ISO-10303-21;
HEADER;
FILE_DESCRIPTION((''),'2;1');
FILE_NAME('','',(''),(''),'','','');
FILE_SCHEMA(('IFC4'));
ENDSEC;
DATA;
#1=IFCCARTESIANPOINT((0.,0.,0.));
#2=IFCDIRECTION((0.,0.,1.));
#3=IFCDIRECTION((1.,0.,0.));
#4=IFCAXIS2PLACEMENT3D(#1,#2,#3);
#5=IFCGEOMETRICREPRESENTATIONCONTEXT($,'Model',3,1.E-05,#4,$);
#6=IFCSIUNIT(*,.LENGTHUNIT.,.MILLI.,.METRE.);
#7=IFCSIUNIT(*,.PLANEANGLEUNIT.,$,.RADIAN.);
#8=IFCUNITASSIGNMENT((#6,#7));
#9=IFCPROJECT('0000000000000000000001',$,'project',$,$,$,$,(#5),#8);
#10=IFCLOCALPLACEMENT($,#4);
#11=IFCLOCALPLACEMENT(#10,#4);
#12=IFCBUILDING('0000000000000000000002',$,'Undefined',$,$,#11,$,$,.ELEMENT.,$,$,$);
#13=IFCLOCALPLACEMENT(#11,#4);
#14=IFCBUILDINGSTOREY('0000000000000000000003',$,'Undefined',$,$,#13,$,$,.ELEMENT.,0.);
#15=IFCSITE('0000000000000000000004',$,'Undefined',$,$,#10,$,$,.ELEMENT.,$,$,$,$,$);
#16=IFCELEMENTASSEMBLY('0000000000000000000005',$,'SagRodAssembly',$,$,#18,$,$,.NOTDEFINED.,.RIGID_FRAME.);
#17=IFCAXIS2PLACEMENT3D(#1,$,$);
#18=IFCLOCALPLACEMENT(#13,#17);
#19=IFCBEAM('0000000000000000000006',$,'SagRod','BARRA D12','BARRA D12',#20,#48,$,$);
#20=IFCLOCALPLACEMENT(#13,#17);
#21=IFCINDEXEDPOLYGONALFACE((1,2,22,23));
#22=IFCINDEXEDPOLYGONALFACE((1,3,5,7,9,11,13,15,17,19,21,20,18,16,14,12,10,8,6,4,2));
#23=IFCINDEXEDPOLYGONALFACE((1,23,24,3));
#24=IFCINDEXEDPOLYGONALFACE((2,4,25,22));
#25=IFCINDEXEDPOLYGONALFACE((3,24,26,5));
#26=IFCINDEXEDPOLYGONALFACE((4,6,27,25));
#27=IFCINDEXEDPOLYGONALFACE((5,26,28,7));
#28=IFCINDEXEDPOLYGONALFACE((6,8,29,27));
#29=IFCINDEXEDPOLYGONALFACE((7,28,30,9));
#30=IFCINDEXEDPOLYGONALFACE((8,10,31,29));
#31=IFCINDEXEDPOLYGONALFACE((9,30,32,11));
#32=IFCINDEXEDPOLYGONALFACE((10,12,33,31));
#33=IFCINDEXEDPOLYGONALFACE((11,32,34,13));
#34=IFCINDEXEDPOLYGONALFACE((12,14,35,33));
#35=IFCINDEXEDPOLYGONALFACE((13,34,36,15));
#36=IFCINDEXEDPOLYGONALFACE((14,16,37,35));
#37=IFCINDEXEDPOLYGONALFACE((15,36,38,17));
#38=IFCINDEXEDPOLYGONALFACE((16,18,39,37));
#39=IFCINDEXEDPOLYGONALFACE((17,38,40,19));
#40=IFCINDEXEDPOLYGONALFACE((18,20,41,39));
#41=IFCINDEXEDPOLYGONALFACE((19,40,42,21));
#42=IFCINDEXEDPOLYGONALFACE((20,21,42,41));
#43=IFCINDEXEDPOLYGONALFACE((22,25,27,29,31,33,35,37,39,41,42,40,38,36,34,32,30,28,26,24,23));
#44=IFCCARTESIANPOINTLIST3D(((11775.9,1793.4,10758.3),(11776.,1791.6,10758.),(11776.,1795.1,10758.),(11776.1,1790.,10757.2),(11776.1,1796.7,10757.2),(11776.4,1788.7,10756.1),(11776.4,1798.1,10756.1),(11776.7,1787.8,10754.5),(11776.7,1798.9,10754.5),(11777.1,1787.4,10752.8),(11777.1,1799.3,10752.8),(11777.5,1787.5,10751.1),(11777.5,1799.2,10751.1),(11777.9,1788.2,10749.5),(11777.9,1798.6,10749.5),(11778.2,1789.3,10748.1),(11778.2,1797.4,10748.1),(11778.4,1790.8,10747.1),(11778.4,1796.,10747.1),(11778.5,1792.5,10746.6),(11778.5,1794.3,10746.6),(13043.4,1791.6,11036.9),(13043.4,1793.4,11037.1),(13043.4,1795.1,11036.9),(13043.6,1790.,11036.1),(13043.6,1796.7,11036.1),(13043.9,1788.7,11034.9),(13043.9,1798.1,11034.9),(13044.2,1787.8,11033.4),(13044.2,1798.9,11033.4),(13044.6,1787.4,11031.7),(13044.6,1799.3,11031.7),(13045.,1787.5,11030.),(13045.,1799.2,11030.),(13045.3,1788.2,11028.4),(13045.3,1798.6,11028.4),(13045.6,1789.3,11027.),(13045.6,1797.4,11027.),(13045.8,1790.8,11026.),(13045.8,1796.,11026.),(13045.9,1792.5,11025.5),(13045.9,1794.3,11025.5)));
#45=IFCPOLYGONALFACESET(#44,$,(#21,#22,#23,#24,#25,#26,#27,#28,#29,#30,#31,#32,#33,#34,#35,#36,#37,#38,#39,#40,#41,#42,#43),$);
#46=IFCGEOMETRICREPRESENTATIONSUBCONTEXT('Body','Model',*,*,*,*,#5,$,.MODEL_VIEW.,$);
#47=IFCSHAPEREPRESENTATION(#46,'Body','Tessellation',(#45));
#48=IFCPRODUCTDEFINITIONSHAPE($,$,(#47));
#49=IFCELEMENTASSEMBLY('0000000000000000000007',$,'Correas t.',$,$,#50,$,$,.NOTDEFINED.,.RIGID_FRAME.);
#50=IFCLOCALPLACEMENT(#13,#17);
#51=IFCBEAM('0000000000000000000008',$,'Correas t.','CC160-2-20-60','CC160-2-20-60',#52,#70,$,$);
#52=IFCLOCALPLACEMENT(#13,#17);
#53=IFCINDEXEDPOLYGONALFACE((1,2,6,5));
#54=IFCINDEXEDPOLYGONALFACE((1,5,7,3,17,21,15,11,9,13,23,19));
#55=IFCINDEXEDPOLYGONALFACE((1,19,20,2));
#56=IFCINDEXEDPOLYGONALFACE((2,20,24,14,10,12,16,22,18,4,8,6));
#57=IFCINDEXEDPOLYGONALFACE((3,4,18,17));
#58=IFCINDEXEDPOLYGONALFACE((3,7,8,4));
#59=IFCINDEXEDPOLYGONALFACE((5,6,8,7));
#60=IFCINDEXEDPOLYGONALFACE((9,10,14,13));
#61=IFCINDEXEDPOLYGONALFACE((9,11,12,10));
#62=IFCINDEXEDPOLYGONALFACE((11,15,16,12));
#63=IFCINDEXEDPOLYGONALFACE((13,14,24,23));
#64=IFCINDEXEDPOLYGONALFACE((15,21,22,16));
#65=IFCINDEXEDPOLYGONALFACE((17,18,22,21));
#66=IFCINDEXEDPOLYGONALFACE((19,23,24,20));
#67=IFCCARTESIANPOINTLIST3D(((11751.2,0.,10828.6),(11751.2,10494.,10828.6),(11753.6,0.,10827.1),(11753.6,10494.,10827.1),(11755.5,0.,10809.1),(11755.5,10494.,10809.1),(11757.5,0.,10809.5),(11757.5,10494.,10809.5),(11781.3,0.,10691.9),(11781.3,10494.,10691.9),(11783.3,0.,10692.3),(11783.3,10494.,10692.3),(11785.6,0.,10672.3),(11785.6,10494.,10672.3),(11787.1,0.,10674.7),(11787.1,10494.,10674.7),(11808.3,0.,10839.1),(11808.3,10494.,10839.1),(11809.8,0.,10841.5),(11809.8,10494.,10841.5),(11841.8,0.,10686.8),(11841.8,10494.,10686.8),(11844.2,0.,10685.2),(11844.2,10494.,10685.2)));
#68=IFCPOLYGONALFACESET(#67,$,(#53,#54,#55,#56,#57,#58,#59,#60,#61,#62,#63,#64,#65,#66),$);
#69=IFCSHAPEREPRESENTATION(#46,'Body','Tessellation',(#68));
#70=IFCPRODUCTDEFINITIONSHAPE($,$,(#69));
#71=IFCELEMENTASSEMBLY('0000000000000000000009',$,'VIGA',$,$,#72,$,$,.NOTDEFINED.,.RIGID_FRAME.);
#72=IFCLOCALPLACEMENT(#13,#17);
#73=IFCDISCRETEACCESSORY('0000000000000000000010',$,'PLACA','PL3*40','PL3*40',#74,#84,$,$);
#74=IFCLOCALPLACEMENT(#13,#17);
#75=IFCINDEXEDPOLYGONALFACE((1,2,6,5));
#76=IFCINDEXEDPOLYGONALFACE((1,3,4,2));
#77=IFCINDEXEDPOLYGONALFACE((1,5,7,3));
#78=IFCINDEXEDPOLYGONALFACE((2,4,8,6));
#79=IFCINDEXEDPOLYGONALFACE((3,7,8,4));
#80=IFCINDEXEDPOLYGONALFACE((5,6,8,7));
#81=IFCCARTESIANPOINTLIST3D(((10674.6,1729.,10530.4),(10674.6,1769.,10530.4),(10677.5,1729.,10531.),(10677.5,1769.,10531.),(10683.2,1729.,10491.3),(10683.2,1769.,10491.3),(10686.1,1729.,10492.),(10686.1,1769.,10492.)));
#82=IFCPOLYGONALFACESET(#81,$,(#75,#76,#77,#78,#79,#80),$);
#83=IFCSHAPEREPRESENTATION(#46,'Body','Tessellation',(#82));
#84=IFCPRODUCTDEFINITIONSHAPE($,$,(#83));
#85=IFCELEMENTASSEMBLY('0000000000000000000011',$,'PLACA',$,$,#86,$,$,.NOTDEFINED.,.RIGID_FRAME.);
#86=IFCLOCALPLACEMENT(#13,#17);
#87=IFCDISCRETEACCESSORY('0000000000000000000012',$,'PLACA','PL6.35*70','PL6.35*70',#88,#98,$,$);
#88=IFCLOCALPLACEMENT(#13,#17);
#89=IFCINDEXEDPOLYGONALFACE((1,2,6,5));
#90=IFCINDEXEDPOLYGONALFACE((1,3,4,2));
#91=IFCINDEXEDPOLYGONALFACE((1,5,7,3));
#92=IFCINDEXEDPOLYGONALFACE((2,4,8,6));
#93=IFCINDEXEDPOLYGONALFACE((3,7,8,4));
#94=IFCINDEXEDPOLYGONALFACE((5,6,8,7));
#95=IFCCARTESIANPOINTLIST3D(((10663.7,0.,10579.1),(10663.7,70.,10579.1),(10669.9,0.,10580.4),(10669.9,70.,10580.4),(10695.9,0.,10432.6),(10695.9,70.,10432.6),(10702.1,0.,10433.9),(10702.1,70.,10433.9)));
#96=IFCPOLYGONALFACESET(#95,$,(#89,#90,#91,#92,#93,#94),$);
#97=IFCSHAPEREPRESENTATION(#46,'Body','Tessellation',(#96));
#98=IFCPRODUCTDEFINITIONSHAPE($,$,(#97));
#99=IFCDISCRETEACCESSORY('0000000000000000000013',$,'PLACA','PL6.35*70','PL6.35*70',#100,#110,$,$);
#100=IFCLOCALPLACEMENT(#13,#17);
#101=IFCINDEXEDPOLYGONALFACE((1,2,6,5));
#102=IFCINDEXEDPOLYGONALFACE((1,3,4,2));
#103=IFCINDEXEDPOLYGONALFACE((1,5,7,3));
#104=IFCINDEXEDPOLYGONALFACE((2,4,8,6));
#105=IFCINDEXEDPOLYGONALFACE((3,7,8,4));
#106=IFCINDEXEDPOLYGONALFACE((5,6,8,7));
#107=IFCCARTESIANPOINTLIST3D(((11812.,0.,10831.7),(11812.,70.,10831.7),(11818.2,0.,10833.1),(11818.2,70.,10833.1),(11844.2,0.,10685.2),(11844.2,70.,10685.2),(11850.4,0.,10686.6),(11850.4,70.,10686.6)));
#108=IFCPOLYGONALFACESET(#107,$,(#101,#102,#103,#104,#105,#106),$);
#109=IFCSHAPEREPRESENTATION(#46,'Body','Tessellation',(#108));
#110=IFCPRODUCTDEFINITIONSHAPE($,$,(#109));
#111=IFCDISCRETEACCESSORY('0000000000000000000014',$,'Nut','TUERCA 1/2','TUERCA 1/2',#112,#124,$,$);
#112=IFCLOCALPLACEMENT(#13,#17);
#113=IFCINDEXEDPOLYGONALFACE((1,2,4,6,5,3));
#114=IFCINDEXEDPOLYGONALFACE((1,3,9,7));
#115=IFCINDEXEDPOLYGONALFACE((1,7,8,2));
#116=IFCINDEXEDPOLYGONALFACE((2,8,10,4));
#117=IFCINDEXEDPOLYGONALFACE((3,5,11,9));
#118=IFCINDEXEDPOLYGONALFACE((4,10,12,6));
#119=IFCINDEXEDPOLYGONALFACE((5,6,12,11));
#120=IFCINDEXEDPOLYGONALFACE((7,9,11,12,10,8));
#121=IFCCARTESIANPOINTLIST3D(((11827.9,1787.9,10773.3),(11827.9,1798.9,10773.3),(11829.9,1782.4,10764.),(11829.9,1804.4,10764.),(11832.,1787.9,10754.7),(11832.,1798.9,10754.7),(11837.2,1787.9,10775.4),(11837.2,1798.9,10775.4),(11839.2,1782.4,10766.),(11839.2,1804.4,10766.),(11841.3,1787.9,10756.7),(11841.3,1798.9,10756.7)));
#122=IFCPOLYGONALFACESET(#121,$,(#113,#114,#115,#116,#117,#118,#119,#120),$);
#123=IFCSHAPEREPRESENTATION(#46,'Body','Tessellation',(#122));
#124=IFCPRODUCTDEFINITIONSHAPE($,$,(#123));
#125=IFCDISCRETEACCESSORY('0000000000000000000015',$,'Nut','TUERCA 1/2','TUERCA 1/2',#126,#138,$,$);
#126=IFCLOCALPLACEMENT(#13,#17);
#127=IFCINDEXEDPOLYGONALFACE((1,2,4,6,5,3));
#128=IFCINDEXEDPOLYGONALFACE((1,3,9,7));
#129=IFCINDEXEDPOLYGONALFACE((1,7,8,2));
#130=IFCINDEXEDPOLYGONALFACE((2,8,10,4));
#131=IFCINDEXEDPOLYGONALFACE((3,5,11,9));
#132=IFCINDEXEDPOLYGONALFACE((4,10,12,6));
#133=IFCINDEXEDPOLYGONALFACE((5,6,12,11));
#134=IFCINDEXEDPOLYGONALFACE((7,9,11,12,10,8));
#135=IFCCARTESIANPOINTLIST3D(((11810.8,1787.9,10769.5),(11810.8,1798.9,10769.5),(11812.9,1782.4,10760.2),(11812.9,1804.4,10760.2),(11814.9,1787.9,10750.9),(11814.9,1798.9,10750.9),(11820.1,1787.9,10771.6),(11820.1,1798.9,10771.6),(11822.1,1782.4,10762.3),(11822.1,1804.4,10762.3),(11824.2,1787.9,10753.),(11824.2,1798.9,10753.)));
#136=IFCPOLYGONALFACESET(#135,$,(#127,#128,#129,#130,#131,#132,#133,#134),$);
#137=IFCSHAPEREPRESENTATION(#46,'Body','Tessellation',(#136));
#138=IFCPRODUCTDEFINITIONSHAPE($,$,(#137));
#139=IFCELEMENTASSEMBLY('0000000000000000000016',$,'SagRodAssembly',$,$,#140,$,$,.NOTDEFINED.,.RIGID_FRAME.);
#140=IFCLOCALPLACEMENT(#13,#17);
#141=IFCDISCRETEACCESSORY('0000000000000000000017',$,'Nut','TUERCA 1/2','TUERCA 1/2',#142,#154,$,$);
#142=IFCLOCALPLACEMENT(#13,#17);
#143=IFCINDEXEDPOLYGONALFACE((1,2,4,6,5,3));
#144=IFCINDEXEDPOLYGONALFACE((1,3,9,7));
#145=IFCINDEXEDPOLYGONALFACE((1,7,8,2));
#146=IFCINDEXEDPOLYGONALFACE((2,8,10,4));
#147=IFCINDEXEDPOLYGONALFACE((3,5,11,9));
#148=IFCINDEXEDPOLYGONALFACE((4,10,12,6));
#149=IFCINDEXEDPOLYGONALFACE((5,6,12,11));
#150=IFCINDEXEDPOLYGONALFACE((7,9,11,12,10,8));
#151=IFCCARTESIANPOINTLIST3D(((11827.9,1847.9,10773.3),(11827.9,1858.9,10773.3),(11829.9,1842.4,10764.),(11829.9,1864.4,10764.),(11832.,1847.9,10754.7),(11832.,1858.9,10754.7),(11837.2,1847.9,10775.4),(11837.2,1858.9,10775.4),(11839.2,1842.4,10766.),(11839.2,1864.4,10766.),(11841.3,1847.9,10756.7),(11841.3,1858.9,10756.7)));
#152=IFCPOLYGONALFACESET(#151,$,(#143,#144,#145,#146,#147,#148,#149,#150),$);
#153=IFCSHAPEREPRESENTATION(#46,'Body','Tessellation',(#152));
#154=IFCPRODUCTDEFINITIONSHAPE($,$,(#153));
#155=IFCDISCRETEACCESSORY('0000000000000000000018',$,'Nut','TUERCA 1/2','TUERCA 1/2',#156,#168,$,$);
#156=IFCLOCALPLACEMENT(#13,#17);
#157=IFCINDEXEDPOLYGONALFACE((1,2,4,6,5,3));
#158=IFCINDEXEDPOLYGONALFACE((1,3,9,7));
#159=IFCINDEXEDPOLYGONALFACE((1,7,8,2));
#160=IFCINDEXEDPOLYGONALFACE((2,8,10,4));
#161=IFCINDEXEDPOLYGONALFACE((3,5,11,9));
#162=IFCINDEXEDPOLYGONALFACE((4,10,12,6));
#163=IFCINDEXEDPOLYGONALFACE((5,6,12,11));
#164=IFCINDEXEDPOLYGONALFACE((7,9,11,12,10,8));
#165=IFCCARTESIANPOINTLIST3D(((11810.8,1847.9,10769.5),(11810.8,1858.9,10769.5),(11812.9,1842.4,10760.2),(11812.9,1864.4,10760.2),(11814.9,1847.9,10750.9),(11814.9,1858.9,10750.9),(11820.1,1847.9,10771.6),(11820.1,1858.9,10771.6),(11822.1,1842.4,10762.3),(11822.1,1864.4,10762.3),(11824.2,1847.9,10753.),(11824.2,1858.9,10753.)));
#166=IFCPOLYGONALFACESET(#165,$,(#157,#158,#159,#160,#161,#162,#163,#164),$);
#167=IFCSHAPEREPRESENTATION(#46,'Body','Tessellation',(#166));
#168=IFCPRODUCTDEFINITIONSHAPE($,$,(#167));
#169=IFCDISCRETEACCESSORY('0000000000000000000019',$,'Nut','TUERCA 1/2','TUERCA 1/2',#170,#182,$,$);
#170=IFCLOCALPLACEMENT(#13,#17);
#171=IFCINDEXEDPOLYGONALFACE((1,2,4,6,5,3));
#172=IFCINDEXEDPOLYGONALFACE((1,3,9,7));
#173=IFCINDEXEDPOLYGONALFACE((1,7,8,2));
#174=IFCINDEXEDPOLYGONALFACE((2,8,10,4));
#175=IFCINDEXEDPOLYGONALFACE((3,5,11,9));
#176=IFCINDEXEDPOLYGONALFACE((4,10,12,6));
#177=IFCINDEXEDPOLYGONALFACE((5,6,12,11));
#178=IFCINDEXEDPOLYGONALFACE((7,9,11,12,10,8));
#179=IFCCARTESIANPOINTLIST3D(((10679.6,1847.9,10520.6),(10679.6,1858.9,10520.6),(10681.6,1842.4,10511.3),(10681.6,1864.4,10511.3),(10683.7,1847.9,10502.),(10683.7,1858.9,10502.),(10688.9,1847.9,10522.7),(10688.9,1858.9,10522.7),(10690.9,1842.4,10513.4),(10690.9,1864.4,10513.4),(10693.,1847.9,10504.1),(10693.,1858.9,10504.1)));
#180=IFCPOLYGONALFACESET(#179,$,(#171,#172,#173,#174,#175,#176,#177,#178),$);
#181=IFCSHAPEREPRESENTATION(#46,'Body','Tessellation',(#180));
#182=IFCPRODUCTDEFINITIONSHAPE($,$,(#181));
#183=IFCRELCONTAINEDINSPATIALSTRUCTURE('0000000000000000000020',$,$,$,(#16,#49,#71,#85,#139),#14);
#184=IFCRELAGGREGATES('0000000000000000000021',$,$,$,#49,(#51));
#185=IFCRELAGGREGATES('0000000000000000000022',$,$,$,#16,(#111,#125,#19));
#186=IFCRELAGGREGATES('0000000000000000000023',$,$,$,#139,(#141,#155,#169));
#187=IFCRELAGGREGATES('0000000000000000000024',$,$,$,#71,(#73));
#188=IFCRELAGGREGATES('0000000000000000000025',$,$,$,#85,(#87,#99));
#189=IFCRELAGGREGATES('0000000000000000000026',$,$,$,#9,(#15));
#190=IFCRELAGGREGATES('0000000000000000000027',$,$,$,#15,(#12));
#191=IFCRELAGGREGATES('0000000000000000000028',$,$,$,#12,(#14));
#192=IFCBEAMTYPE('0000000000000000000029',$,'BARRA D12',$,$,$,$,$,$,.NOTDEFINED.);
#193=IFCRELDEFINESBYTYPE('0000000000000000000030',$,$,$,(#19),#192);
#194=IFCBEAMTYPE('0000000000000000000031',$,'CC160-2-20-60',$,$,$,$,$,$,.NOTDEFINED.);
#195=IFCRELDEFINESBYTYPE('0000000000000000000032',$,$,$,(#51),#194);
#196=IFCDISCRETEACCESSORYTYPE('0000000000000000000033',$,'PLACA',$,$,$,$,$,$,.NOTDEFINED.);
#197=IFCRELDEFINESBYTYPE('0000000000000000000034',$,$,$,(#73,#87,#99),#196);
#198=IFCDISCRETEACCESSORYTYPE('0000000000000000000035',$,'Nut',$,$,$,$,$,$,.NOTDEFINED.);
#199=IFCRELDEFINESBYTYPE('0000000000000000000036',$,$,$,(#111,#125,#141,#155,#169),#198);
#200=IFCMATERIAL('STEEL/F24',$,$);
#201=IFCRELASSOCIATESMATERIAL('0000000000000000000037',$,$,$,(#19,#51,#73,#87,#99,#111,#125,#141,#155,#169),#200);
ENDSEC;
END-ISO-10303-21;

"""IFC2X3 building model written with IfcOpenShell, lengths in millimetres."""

from ifc_helpers import new_model, si_unit, frame, origin_with_axes, origin_2d_with_axis, place, context, subcontext, project, spatial, polyline, rectangle, circle, c_section, outline, extrude, clip, halfspace, material, type_object, element, aggregate, save


model = new_model("IFC2X3")

# Units and contexts
model_context = context("Model", 3, precision=1e-05, world=origin_with_axes())
body_context = subcontext(model_context, "Body", "Model", "MODEL_VIEW")
ifc_project = project(units=[si_unit("LENGTHUNIT", "METRE", prefix="MILLI"), si_unit("PLANEANGLEUNIT", "RADIAN")], contexts=[model_context])

# Site, building, storey
site_placement = place(None, origin_with_axes())
site = spatial("IfcSite", under=ifc_project, at=site_placement, Name="Undefined", CompositionType="ELEMENT")
building_placement = place(site_placement, origin_with_axes())
building = spatial("IfcBuilding", under=site, at=building_placement, Name="Undefined", CompositionType="ELEMENT")
storey_placement = place(building_placement, origin_with_axes())
storey = spatial("IfcBuildingStorey", under=building, at=storey_placement, Name="Undefined", CompositionType="ELEMENT", Elevation=0.0)

# Element assemblies, beams
assembly_1_placement = place(storey_placement, origin_with_axes())
assembly_1 = element("IfcElementAssembly", 1, at=assembly_1_placement, inside=storey, Name="SagRodAssembly", AssemblyPlace="NOTDEFINED", PredefinedType="RIGID_FRAME")
ifc_material_1 = material(Name="STEEL/F24")
beam_type_1 = type_object("IfcBeamType", Name="BARRA D12", PredefinedType="NOTDEFINED")
beam_1_placement = place(assembly_1_placement, frame((11777.2, 1793.4, 10752.4), z_axis=(0.0, 1.0, 0.0), x_axis=(0.976639, 0.0, 0.214887)))
beam_1 = element("IfcBeam", 2, at=beam_1_placement, type_object=beam_type_1, material=ifc_material_1, Name="SagRod", Description="BARRA D12", ObjectType="BARRA D12", context=body_context, shape_type="SweptSolid", body=[
    extrude(circle(Radius=6.0, at=origin_2d_with_axis()), frame((1297.8, 0.0, 0.0), z_axis=(-1.0, 0.0, 0.0), x_axis=(0.0, -1.0, 0.0)), (0.0, 0.0, 1.0), 1297.8),
])
assembly_2_placement = place(storey_placement, origin_with_axes())
assembly_2 = element("IfcElementAssembly", 3, at=assembly_2_placement, inside=storey, Name="Correas t.", AssemblyPlace="NOTDEFINED", PredefinedType="RIGID_FRAME")
beam_type_2 = type_object("IfcBeamType", Name="CC160-2-20-60", PredefinedType="NOTDEFINED")
beam_2_placement = place(assembly_2_placement, frame((11797.7, 0.0, 10756.9), z_axis=(0.214887, 0.0, -0.976639), x_axis=(0.0, 1.0, 0.0)))
beam_2 = element("IfcBeam", 4, at=beam_2_placement, type_object=beam_type_2, material=ifc_material_1, Name="Correas t.", Description="CC160-2-20-60", ObjectType="CC160-2-20-60", context=body_context, shape_type="Clipping", body=[
    clip(extrude(c_section(Depth=160.0, Width=60.0, WallThickness=2.0, Girth=20.0, at=origin_2d_with_axis()), frame((10500.0, 0.0, 0.0), z_axis=(-1.0, 0.0, 0.0), x_axis=(0.0, -1.0, 0.0)), (0.0, 0.0, 1.0), 10500.0), halfspace(frame((10494.0, -30.0, -80.0), z_axis=(1.0, 0.0, 0.000029), x_axis=(-0.000029, 0.0, 1.0)), False)),
])
aggregate(assembly_2, [beam_2])

# Element assembly, discrete accessory
assembly_3_placement = place(storey_placement, origin_with_axes())
assembly_3 = element("IfcElementAssembly", 5, at=assembly_3_placement, inside=storey, Name="VIGA", AssemblyPlace="NOTDEFINED", PredefinedType="RIGID_FRAME")
discrete_accessory_type_1 = type_object("IfcDiscreteAccessoryType", Name="PLACA")
discrete_accessory_1_placement = place(assembly_3_placement, frame((10676.0, 1729.0, 10530.7), z_axis=(-0.976635, 0.0, -0.214906), x_axis=(0.0, 1.0, 0.0)))
discrete_accessory_1 = element("IfcDiscreteAccessory", 6, at=discrete_accessory_1_placement, type_object=discrete_accessory_type_1, material=ifc_material_1, Name="PLACA", Description="PL3*40", ObjectType="PL3*40", context=body_context, shape_type="SweptSolid", body=[
    extrude(outline(polyline([(0.0, 0.0), (40.0, 0.0), (40.0, 40.0), (0.0, 40.0), (0.0, 0.0)])), frame((0.0, 0.0, -1.5), z_axis=(0.0, 0.0, 1.0), x_axis=(1.0, 0.0, 0.0)), (0.0, 0.0, 1.0), 3.0),
])

# Element assembly, discrete accessories
assembly_4_placement = place(storey_placement, origin_with_axes())
assembly_4 = element("IfcElementAssembly", 7, at=assembly_4_placement, inside=storey, Name="PLACA", AssemblyPlace="NOTDEFINED", PredefinedType="RIGID_FRAME")
discrete_accessory_2_placement = place(assembly_4_placement, frame((10666.8, 35.0, 10579.7), z_axis=(0.0, 1.0, 0.0), x_axis=(0.214887, 0.0, -0.976639)))
discrete_accessory_2 = element("IfcDiscreteAccessory", 8, at=discrete_accessory_2_placement, type_object=discrete_accessory_type_1, material=ifc_material_1, Name="PLACA", Description="PL6.35*70", ObjectType="PL6.35*70", context=body_context, shape_type="SweptSolid", body=[
    extrude(rectangle(XDim=6.3, YDim=70.0, at=origin_2d_with_axis()), frame((150.0, 0.0, 0.0), z_axis=(-1.0, 0.0, 0.0), x_axis=(0.0, -1.0, 0.0)), (0.0, 0.0, 1.0), 150.0),
])
discrete_accessory_3_placement = place(assembly_4_placement, frame((11815.1, 35.0, 10832.4), z_axis=(0.0, 1.0, 0.0), x_axis=(0.214887, 0.0, -0.976639)))
discrete_accessory_3 = element("IfcDiscreteAccessory", 9, at=discrete_accessory_3_placement, type_object=discrete_accessory_type_1, material=ifc_material_1, Name="PLACA", Description="PL6.35*70", ObjectType="PL6.35*70", context=body_context, shape_type="SweptSolid", body=[
    extrude(rectangle(XDim=6.3, YDim=70.0, at=origin_2d_with_axis()), frame((150.0, 0.0, 0.0), z_axis=(-1.0, 0.0, 0.0), x_axis=(0.0, -1.0, 0.0)), (0.0, 0.0, 1.0), 150.0),
])

# Discrete accessories
discrete_accessory_type_2 = type_object("IfcDiscreteAccessoryType", Name="Nut")
discrete_accessory_4_placement = place(assembly_1_placement, frame((11829.9, 1793.4, 10764.0), z_axis=(-0.214887, 0.0, 0.976639), x_axis=(0.976639, 0.0, 0.214887)))
discrete_accessory_4 = element("IfcDiscreteAccessory", 10, at=discrete_accessory_4_placement, type_object=discrete_accessory_type_2, material=ifc_material_1, Name="Nut", Description="TUERCA 1/2", ObjectType="TUERCA 1/2", context=body_context, shape_type="SweptSolid", body=[
    extrude(outline(polyline([(-5.5, 9.5), (5.5, 9.5), (11.0, 0.0), (5.5, -9.5), (-5.5, -9.5), (-11.0, 0.0), (-5.5, 9.5)])), frame((9.5, 0.0, 0.0), z_axis=(-1.0, 0.0, 0.0), x_axis=(0.0, -1.0, 0.0)), (0.0, 0.0, 1.0), 9.5),
])
discrete_accessory_5_placement = place(assembly_1_placement, frame((11812.9, 1793.4, 10760.2), z_axis=(-0.214887, 0.0, 0.976639), x_axis=(0.976639, 0.0, 0.214887)))
discrete_accessory_5 = element("IfcDiscreteAccessory", 11, at=discrete_accessory_5_placement, type_object=discrete_accessory_type_2, material=ifc_material_1, Name="Nut", Description="TUERCA 1/2", ObjectType="TUERCA 1/2", context=body_context, shape_type="SweptSolid", body=[
    extrude(outline(polyline([(-5.5, 9.5), (5.5, 9.5), (11.0, 0.0), (5.5, -9.5), (-5.5, -9.5), (-11.0, 0.0), (-5.5, 9.5)])), frame((9.5, 0.0, 0.0), z_axis=(-1.0, 0.0, 0.0), x_axis=(0.0, -1.0, 0.0)), (0.0, 0.0, 1.0), 9.5),
])

# Element assembly, discrete accessories
assembly_5_placement = place(storey_placement, origin_with_axes())
assembly_5 = element("IfcElementAssembly", 12, at=assembly_5_placement, inside=storey, Name="SagRodAssembly", AssemblyPlace="NOTDEFINED", PredefinedType="RIGID_FRAME")
discrete_accessory_6_placement = place(assembly_5_placement, frame((11829.9, 1853.4, 10764.0), z_axis=(-0.214887, 0.0, 0.976639), x_axis=(0.976639, 0.0, 0.214887)))
discrete_accessory_6 = element("IfcDiscreteAccessory", 13, at=discrete_accessory_6_placement, type_object=discrete_accessory_type_2, material=ifc_material_1, Name="Nut", Description="TUERCA 1/2", ObjectType="TUERCA 1/2", context=body_context, shape_type="SweptSolid", body=[
    extrude(outline(polyline([(-5.5, 9.5), (5.5, 9.5), (11.0, 0.0), (5.5, -9.5), (-5.5, -9.5), (-11.0, 0.0), (-5.5, 9.5)])), frame((9.5, 0.0, 0.0), z_axis=(-1.0, 0.0, 0.0), x_axis=(0.0, -1.0, 0.0)), (0.0, 0.0, 1.0), 9.5),
])
discrete_accessory_7_placement = place(assembly_5_placement, frame((11812.9, 1853.4, 10760.2), z_axis=(-0.214887, 0.0, 0.976639), x_axis=(0.976639, 0.0, 0.214887)))
discrete_accessory_7 = element("IfcDiscreteAccessory", 14, at=discrete_accessory_7_placement, type_object=discrete_accessory_type_2, material=ifc_material_1, Name="Nut", Description="TUERCA 1/2", ObjectType="TUERCA 1/2", context=body_context, shape_type="SweptSolid", body=[
    extrude(outline(polyline([(-5.5, 9.5), (5.5, 9.5), (11.0, 0.0), (5.5, -9.5), (-5.5, -9.5), (-11.0, 0.0), (-5.5, 9.5)])), frame((9.5, 0.0, 0.0), z_axis=(-1.0, 0.0, 0.0), x_axis=(0.0, -1.0, 0.0)), (0.0, 0.0, 1.0), 9.5),
])
discrete_accessory_8_placement = place(assembly_5_placement, frame((10681.6, 1853.4, 10511.3), z_axis=(-0.214887, 0.0, 0.976639), x_axis=(0.976639, 0.0, 0.214887)))
discrete_accessory_8 = element("IfcDiscreteAccessory", 15, at=discrete_accessory_8_placement, type_object=discrete_accessory_type_2, material=ifc_material_1, Name="Nut", Description="TUERCA 1/2", ObjectType="TUERCA 1/2", context=body_context, shape_type="SweptSolid", body=[
    extrude(outline(polyline([(-5.5, 9.5), (5.5, 9.5), (11.0, 0.0), (5.5, -9.5), (-5.5, -9.5), (-11.0, 0.0), (-5.5, 9.5)])), frame((9.5, 0.0, 0.0), z_axis=(-1.0, 0.0, 0.0), x_axis=(0.0, -1.0, 0.0)), (0.0, 0.0, 1.0), 9.5),
])

aggregate(assembly_1, [discrete_accessory_4, discrete_accessory_5, beam_1])
aggregate(assembly_5, [discrete_accessory_6, discrete_accessory_7, discrete_accessory_8])

aggregate(assembly_3, [discrete_accessory_1])
aggregate(assembly_4, [discrete_accessory_2, discrete_accessory_3])

save(model, "model.ifc")
